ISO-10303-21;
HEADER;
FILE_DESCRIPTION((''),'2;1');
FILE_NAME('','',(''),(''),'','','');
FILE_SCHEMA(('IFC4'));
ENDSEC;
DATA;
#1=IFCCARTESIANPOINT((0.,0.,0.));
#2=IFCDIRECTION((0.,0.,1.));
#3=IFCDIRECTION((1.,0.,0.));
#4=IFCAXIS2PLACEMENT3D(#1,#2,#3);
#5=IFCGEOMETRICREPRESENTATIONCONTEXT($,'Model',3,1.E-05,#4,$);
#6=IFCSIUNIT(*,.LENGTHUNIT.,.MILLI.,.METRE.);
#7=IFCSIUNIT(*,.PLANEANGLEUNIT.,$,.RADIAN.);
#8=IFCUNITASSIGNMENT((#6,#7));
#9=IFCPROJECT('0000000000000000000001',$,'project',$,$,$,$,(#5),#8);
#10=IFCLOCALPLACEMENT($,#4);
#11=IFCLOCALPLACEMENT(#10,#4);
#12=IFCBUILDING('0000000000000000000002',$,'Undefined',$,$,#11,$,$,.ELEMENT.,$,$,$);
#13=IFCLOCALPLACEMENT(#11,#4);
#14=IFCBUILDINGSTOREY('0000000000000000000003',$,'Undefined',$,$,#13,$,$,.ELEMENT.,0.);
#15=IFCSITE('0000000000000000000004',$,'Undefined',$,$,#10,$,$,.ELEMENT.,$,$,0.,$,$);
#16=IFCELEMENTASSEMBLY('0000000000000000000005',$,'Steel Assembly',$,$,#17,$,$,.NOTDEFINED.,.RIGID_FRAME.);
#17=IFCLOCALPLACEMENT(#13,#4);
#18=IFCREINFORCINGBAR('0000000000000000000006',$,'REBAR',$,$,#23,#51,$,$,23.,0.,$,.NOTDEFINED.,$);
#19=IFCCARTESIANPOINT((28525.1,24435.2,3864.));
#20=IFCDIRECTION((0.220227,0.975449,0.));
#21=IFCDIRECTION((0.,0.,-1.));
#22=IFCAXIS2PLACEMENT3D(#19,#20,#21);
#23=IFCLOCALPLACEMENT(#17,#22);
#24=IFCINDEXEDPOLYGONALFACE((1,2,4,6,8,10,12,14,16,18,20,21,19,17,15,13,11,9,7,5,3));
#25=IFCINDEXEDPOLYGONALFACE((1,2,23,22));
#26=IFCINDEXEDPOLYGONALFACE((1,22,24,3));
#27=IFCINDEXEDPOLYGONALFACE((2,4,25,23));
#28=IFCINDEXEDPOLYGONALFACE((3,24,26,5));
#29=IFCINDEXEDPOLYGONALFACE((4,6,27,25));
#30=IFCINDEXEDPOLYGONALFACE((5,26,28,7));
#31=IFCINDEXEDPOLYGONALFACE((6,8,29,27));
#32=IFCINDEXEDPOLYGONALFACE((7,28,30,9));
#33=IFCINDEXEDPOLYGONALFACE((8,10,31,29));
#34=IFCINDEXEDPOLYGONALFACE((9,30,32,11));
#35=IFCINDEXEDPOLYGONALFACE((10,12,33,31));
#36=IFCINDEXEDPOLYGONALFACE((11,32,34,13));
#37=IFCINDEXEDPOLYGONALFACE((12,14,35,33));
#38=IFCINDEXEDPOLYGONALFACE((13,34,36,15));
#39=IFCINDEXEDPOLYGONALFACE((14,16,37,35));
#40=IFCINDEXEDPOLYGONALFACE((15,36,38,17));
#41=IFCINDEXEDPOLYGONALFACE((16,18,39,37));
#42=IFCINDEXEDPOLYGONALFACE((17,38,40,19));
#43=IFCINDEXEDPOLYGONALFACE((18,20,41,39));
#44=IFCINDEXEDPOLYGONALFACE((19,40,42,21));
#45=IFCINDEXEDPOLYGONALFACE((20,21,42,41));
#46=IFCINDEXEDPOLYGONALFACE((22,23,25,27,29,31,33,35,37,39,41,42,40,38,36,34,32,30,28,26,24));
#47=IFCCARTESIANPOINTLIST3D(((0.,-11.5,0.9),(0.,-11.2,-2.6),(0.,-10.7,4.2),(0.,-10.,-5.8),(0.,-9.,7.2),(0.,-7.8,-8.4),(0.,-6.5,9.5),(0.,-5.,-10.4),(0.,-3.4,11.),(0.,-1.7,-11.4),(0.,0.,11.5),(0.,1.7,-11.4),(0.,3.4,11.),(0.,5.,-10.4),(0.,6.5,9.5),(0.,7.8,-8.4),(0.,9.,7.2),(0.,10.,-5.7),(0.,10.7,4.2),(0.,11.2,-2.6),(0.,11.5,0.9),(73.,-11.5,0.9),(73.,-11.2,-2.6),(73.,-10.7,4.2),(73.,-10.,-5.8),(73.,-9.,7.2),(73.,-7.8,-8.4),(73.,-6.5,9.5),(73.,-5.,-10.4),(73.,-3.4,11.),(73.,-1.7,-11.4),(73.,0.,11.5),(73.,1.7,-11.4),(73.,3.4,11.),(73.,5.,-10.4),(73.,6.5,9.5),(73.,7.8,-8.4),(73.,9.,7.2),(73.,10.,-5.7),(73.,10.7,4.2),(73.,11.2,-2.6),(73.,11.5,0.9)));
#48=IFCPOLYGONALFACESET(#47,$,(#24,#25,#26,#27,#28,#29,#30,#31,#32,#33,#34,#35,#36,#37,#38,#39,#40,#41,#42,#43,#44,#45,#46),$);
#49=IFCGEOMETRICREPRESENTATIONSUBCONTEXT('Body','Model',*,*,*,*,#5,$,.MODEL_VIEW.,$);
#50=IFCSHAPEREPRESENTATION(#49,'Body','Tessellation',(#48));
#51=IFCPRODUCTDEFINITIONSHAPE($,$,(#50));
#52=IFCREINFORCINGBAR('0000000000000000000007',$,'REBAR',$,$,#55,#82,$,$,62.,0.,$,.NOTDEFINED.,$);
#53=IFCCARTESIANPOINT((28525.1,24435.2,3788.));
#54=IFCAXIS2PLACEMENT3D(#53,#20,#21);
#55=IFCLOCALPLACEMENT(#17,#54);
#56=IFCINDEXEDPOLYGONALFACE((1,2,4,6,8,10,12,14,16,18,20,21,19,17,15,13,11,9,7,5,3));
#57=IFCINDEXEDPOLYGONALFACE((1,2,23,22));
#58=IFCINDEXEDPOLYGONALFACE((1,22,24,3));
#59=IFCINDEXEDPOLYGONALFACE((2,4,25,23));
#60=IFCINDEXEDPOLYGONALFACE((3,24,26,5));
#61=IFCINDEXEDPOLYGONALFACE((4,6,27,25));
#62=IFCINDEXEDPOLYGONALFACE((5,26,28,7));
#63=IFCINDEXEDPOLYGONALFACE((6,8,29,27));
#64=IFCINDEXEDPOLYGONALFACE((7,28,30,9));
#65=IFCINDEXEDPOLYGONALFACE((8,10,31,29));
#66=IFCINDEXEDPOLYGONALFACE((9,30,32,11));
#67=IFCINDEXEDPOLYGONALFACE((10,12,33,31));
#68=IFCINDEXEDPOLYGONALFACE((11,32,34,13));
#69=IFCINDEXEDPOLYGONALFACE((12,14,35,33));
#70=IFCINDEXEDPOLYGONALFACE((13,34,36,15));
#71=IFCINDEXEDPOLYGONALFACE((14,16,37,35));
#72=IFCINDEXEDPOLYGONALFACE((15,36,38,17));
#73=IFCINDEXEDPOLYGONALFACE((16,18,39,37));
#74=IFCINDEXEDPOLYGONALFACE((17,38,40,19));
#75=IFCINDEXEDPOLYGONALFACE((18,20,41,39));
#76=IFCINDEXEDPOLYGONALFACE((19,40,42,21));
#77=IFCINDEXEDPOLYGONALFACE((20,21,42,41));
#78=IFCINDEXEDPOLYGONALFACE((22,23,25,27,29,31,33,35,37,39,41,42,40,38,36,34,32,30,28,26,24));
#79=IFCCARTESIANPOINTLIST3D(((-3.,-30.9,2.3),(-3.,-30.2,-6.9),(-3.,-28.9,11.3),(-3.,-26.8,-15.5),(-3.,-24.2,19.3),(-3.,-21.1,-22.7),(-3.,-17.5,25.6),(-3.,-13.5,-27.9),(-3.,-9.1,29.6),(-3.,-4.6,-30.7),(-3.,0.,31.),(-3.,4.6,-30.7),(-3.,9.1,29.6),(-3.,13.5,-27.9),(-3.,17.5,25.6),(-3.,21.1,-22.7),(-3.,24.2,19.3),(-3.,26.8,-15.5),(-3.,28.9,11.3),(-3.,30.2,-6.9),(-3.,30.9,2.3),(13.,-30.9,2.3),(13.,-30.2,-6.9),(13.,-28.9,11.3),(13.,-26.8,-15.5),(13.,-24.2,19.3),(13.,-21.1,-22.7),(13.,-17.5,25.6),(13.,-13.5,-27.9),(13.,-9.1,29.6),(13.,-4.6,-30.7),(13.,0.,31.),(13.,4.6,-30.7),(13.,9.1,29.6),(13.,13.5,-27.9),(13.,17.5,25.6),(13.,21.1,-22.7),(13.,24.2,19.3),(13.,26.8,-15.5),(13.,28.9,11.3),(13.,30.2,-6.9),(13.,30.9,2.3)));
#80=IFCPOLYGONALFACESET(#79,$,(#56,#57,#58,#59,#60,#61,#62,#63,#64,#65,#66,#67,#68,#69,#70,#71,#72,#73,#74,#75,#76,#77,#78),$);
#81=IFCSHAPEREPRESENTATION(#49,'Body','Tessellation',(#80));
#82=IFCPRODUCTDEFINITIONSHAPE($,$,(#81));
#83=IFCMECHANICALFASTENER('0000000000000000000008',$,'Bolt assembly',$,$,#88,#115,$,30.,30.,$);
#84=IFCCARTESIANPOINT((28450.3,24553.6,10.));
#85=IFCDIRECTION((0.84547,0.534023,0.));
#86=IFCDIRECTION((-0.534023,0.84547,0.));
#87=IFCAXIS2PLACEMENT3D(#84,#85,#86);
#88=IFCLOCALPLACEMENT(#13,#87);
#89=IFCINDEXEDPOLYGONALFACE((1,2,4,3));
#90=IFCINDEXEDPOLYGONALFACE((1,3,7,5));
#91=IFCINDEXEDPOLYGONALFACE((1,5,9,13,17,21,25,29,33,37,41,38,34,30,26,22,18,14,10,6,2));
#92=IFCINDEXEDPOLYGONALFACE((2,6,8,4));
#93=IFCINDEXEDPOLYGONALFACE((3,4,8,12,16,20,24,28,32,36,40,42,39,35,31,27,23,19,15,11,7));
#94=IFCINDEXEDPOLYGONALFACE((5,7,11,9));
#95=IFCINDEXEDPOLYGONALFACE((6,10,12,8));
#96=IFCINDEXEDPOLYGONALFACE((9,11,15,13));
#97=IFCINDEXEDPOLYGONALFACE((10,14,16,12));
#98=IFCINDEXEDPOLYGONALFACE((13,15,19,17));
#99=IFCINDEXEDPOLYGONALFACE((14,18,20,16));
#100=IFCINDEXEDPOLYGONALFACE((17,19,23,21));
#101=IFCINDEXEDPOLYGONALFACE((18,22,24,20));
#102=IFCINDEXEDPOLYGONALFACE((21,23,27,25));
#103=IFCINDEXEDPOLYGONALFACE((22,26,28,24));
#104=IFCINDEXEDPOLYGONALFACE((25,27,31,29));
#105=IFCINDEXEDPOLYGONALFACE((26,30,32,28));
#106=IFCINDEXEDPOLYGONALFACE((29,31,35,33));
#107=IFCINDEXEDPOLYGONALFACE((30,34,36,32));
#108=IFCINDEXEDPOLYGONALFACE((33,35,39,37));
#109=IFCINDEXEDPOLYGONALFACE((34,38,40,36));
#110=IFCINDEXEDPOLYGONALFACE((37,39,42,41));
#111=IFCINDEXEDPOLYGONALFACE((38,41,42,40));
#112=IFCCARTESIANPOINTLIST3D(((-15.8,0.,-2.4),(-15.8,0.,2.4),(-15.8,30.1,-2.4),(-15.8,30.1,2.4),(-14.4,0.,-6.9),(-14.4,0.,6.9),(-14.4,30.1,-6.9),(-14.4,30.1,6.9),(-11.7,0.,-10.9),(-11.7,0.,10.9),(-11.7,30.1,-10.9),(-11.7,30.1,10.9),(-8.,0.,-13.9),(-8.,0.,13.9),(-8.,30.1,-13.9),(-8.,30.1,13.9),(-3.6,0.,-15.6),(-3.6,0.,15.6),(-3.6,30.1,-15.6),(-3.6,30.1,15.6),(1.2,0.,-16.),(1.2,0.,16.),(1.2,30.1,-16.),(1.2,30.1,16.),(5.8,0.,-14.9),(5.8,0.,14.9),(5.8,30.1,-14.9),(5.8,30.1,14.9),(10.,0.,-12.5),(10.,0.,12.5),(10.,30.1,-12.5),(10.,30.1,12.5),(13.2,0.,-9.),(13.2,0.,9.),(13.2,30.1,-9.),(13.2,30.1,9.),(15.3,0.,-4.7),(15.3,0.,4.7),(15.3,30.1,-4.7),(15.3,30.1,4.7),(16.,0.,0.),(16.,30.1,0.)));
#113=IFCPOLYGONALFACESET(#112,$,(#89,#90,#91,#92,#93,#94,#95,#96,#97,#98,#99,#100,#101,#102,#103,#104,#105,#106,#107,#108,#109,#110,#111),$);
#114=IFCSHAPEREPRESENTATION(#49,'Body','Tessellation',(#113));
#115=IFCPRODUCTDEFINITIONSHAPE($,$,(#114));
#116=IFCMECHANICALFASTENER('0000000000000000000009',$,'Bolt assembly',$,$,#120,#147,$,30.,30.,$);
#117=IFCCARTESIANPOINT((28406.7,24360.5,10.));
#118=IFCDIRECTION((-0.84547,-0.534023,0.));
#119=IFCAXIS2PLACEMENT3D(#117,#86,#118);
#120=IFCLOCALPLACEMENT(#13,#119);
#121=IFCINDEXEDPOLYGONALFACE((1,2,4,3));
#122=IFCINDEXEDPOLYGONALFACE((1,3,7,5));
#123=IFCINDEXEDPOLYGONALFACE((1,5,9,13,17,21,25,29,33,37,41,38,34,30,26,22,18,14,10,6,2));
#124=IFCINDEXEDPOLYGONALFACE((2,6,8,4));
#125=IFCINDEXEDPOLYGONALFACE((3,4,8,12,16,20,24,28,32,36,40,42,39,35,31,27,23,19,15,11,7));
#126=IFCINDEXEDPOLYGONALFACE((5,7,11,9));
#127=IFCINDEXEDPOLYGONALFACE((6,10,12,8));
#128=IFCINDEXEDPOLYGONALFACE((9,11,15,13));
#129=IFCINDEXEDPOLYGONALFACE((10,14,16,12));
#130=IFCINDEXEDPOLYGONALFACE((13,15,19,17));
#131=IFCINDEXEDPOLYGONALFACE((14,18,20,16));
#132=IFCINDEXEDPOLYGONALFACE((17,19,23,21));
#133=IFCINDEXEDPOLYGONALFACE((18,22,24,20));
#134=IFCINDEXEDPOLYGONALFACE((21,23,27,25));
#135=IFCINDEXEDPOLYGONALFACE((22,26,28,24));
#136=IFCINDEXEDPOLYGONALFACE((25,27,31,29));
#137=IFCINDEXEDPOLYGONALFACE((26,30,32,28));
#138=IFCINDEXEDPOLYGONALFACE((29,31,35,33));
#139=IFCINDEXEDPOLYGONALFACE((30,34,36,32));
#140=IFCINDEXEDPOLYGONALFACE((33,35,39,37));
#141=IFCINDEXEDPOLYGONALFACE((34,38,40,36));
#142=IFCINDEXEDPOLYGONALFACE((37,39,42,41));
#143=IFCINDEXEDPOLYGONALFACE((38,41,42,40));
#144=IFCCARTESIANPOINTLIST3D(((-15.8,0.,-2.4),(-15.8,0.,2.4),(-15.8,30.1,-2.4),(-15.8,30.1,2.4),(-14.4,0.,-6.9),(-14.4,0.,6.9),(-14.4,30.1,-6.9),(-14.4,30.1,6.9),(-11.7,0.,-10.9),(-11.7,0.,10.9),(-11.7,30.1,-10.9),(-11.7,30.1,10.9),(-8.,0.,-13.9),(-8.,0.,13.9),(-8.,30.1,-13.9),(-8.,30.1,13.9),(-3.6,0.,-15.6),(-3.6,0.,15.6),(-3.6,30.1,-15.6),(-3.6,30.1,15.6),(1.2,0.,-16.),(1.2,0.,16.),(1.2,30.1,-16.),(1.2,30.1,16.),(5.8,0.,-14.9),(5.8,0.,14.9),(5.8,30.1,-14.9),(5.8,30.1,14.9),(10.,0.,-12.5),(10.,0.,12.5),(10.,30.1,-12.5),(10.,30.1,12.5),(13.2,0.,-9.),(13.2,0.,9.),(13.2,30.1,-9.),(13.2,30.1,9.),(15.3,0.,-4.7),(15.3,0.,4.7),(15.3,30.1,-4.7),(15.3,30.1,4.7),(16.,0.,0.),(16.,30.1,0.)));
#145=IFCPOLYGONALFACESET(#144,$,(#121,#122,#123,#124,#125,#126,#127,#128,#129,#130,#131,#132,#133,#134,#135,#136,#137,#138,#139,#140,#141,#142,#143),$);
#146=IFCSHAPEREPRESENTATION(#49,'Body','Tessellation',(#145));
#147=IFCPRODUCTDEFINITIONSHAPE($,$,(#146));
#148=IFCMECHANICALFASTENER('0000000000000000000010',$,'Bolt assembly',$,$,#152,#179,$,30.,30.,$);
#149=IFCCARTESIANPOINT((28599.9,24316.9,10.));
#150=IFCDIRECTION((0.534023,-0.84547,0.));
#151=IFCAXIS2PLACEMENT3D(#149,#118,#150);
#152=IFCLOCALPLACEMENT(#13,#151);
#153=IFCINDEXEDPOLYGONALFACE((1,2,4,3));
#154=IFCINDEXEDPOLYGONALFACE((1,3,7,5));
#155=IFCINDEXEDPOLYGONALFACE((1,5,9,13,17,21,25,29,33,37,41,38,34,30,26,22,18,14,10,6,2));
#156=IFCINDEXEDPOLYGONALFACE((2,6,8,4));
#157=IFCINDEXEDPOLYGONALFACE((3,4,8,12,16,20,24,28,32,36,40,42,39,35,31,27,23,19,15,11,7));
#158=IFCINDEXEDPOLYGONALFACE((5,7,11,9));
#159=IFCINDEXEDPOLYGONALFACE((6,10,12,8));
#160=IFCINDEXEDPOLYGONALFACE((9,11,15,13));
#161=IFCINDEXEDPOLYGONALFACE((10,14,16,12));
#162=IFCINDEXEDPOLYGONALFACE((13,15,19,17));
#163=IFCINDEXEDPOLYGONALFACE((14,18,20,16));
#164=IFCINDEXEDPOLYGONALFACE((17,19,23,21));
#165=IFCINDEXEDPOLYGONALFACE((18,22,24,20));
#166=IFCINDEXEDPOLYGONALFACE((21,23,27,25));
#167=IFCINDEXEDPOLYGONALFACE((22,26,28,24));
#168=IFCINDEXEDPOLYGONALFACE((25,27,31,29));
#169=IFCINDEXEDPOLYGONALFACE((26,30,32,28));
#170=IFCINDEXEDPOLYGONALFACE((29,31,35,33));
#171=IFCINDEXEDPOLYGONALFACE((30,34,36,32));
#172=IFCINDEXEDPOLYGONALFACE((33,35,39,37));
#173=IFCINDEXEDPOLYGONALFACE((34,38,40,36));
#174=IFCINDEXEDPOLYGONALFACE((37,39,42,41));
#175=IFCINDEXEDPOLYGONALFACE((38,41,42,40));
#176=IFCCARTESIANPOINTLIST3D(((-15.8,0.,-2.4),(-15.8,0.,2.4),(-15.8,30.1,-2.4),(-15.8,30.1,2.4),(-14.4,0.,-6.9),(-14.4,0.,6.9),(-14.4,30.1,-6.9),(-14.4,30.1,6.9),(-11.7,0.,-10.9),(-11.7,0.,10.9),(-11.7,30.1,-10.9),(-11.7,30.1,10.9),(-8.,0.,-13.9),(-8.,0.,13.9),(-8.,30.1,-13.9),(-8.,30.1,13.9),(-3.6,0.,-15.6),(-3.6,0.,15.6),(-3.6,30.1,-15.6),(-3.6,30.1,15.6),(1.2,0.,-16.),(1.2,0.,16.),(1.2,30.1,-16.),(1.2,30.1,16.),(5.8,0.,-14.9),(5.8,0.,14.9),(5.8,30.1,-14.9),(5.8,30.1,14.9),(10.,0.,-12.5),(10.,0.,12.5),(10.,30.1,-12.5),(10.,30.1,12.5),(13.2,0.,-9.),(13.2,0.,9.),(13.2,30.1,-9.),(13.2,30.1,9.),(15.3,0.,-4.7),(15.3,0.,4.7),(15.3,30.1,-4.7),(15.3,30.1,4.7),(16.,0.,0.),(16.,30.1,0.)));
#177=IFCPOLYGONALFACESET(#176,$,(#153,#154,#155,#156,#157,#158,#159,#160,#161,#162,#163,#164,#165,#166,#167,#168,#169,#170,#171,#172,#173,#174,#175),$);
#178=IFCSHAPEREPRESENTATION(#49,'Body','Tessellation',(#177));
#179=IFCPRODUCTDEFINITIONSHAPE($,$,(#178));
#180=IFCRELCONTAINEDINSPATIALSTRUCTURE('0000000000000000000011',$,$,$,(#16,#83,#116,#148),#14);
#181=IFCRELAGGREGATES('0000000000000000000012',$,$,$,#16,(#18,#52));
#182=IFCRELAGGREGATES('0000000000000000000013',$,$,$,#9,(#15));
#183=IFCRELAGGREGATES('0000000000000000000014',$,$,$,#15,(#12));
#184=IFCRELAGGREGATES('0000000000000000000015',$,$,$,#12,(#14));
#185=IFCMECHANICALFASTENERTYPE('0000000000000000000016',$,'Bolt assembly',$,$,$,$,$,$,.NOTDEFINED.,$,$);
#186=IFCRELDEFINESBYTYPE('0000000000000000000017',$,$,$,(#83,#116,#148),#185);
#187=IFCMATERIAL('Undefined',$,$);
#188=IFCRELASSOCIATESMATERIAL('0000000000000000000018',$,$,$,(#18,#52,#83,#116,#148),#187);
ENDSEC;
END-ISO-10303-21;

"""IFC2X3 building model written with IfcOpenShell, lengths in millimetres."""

from ifc_helpers import new_model, entity, si_unit, frame, origin_with_axes, origin_2d_with_axis, place, context, subcontext, project, spatial, circle, extrude, source, transform, mapped, material, type_object, element, aggregate, save


model = new_model("IFC2X3")

# Units and contexts
model_context = context("Model", 3, precision=1e-05, world=origin_with_axes())
body_context = subcontext(model_context, "Body", "Model", "MODEL_VIEW")
ifc_project = project(units=[si_unit("LENGTHUNIT", "METRE", prefix="MILLI"), si_unit("PLANEANGLEUNIT", "RADIAN")], contexts=[model_context])

# Site, building, storey
site_placement = place(None, origin_with_axes())
site = spatial("IfcSite", under=ifc_project, at=site_placement, Name="Undefined", CompositionType="ELEMENT", RefElevation=0.0)
building_placement = place(site_placement, origin_with_axes())
building = spatial("IfcBuilding", under=site, at=building_placement, Name="Undefined", CompositionType="ELEMENT")
storey_placement = place(building_placement, origin_with_axes())
storey = spatial("IfcBuildingStorey", under=building, at=storey_placement, Name="Undefined", CompositionType="ELEMENT", Elevation=0.0)

# Element assembly
assembly_1_placement = place(storey_placement, origin_with_axes())
assembly_1 = element("IfcElementAssembly", 1, at=assembly_1_placement, inside=storey, Name="Steel Assembly", AssemblyPlace="NOTDEFINED", PredefinedType="RIGID_FRAME")

# Reinforcing bars
ifc_material_1 = material(Name="Undefined")
shared_shape_1 = source(origin_with_axes(), body_context, "Body", "AdvancedSweptSolid", [
    entity("IfcSweptDiskSolid", entity("IfcTrimmedCurve", entity("IfcLine", entity("IfcCartesianPoint", [0.0, 0.0, 0.0]), entity("IfcVector", entity("IfcDirection", [1.0, 0.0, 0.0]), 1.0)), [entity("IfcParameterValue", 0.0)], [entity("IfcParameterValue", 73.0)], True, "PARAMETER"), 11.5, None, 0.0, 73.0),
])
reinforcing_bar_1_placement = place(assembly_1_placement, frame((28525.1, 24435.2, 3864.0), z_axis=(0.220227, 0.975449, 0.0), x_axis=(0.0, 0.0, -1.0)))
reinforcing_bar_1 = element("IfcReinforcingBar", 2, at=reinforcing_bar_1_placement, material=ifc_material_1, Name="REBAR", BarRole="NOTDEFINED", CrossSectionArea=0.0, NominalDiameter=23.0, context=body_context, shape_type="MappedRepresentation", body=[
    mapped(shared_shape_1, transform((0.0, 0.0, 0.0))),
])
shared_shape_2 = source(origin_with_axes(), body_context, "Body", "AdvancedSweptSolid", [
    entity("IfcSweptDiskSolid", entity("IfcTrimmedCurve", entity("IfcLine", entity("IfcCartesianPoint", [0.0, 0.0, 0.0]), entity("IfcVector", entity("IfcDirection", [1.0, 0.0, 0.0]), 1.0)), [entity("IfcParameterValue", 0.0)], [entity("IfcParameterValue", 16.0)], True, "PARAMETER"), 31.0, None, 0.0, 16.0),
])
reinforcing_bar_2_placement = place(assembly_1_placement, frame((28525.1, 24435.2, 3788.0), z_axis=(0.220227, 0.975449, 0.0), x_axis=(0.0, 0.0, -1.0)))
reinforcing_bar_2 = element("IfcReinforcingBar", 3, at=reinforcing_bar_2_placement, material=ifc_material_1, Name="REBAR", BarRole="NOTDEFINED", CrossSectionArea=0.0, NominalDiameter=62.0, context=body_context, shape_type="MappedRepresentation", body=[
    mapped(shared_shape_2, transform((-3.0, 0.0, 0.0))),
])
aggregate(assembly_1, [reinforcing_bar_1, reinforcing_bar_2])

# Mechanical fasteners
mechanical_fastener_type = type_object("IfcMechanicalFastenerType", Name="Bolt assembly")
shared_shape_3 = source(origin_with_axes(), body_context, "Body", "SweptSolid", [
    extrude(circle(Radius=16.0, at=origin_2d_with_axis()), frame((0.0, 0.0, 0.0), z_axis=(0.0, 1.0, 0.0), x_axis=(1.0, 0.0, 0.0)), (0.0, 0.0, 1.0), 30.1),
])
for number, where, z_axis, x_axis, name in (
    (4, (28450.3, 24553.6, 10.0), (0.84547, 0.534023, 0.0), (-0.534023, 0.84547, 0.0), "Bolt assembly"),
    (5, (28406.7, 24360.5, 10.0), (-0.534023, 0.84547, 0.0), (-0.84547, -0.534023, 0.0), "Bolt assembly"),
    (6, (28599.9, 24316.9, 10.0), (-0.84547, -0.534023, 0.0), (0.534023, -0.84547, 0.0), "Bolt assembly"),
):
    element("IfcMechanicalFastener", number, at=place(storey_placement, frame(where, z_axis=z_axis, x_axis=x_axis)), inside=storey, type_object=mechanical_fastener_type, material=ifc_material_1, Name=name, NominalDiameter=30.0, NominalLength=30.0, context=body_context, shape_type="MappedRepresentation", body=[
        mapped(shared_shape_3, transform((0.0, 0.0, 0.0))),
    ])

save(model, "model.ifc")
